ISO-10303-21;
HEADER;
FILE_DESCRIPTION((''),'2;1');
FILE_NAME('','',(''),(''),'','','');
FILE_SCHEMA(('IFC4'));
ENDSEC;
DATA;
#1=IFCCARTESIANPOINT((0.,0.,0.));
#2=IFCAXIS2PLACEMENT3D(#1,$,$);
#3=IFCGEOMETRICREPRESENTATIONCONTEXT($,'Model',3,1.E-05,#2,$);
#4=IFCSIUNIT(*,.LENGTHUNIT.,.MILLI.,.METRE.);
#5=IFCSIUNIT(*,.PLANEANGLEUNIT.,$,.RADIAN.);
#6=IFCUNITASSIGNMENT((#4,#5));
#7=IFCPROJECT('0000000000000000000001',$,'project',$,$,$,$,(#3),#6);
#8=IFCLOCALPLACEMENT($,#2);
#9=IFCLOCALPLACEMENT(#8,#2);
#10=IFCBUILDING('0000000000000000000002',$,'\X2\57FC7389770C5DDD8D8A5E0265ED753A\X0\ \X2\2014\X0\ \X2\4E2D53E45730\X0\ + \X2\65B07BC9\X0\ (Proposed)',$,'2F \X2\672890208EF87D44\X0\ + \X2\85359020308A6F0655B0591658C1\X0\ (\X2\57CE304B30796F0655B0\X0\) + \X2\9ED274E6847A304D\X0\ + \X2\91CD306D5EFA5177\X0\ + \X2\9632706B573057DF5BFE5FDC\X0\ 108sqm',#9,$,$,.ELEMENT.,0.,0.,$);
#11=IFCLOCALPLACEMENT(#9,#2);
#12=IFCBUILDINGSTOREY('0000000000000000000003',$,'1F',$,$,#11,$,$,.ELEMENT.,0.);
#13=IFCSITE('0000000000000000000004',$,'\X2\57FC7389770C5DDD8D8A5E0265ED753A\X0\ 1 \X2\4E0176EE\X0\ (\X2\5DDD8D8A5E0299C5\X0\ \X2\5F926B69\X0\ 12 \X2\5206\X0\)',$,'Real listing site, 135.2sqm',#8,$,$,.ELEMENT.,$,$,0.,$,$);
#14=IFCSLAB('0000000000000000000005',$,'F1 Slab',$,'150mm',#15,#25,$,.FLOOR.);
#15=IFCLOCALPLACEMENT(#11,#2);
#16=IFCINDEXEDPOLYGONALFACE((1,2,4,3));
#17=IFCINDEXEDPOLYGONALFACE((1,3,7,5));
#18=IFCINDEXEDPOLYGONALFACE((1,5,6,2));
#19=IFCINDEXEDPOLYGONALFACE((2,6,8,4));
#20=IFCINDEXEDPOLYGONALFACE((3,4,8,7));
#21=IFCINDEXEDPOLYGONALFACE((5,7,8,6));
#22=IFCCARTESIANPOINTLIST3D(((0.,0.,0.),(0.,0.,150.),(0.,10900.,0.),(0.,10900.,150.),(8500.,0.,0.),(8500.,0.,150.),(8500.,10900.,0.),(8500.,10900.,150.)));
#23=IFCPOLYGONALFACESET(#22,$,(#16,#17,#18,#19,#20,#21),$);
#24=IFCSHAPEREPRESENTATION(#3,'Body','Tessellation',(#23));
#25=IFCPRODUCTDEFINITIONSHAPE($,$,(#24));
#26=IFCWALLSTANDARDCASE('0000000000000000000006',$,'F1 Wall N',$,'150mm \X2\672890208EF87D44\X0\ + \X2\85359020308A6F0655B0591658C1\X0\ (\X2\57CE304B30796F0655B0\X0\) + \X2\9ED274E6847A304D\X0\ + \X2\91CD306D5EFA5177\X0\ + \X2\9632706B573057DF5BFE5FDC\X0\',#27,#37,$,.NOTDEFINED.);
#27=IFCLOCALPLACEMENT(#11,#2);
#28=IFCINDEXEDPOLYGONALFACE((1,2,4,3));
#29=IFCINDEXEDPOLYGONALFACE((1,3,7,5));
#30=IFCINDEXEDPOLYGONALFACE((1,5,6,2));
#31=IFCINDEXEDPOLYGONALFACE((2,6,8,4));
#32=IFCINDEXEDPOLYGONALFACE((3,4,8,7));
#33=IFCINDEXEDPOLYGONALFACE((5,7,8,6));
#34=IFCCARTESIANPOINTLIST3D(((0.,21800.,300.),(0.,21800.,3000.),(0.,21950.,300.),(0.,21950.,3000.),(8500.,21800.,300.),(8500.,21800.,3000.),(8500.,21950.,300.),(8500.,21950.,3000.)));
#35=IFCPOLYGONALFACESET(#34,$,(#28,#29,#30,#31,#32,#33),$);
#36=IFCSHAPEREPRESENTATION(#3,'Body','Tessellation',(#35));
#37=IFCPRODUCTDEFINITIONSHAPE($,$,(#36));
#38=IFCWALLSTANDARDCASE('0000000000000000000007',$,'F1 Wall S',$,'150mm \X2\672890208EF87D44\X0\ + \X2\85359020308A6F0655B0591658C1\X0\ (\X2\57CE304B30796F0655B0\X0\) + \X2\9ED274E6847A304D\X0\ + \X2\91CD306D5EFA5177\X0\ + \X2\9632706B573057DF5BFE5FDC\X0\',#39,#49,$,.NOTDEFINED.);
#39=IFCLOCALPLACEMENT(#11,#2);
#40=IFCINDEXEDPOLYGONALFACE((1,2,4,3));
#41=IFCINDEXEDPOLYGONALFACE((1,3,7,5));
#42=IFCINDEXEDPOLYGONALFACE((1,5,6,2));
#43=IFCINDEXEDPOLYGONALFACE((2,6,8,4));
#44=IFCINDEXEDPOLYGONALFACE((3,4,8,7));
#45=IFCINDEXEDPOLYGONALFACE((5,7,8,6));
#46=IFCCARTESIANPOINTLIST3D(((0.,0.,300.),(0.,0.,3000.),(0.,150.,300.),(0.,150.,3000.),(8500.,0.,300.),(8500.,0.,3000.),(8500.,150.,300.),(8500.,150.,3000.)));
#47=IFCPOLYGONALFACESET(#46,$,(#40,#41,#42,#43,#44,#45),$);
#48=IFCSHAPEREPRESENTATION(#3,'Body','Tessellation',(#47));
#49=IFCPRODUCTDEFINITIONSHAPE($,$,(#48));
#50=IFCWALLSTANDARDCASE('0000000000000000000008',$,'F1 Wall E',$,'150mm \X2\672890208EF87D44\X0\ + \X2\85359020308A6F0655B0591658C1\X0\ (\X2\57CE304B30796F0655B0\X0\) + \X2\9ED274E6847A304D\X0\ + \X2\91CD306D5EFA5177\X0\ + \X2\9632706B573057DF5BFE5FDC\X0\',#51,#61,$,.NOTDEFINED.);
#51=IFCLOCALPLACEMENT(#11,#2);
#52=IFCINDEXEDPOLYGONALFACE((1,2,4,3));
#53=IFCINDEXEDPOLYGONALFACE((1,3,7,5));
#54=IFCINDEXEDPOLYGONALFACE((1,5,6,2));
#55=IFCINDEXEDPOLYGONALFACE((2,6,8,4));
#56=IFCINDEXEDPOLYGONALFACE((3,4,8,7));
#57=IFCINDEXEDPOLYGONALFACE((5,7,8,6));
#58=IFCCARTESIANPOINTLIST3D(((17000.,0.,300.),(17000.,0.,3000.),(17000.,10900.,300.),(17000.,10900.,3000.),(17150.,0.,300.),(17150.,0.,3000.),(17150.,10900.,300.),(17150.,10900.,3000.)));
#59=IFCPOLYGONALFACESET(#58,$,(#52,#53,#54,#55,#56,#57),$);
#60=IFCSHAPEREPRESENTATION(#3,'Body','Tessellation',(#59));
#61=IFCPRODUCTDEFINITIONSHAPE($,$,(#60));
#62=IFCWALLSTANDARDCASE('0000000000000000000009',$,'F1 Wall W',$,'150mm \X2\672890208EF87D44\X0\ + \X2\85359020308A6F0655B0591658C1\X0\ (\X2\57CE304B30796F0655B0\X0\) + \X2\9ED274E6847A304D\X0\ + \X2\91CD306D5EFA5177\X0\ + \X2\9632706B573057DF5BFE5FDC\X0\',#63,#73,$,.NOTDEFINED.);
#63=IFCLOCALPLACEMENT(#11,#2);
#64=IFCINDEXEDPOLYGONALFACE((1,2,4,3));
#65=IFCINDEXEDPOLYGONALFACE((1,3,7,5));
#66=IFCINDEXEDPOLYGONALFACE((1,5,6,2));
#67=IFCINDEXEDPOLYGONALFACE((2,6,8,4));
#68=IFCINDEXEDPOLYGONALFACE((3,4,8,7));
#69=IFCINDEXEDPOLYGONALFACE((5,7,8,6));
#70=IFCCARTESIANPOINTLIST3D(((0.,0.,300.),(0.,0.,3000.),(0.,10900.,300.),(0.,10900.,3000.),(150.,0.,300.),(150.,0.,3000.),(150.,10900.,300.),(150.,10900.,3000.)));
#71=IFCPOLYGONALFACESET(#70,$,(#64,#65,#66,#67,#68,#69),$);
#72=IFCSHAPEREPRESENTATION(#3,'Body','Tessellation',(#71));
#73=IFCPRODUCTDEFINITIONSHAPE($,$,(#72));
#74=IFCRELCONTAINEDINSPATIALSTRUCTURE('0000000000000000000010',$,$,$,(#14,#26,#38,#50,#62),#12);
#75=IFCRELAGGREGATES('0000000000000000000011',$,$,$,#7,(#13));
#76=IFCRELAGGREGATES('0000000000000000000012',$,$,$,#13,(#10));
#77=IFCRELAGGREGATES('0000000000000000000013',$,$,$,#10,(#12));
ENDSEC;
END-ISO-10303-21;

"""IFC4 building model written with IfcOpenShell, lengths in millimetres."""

from ifc_helpers import new_model, si_unit, frame, frame_2d, origin, place, context, project, spatial, rectangle, extrude, element, save


model = new_model("IFC4")

# Units and contexts
model_context = context("Model", 3, precision=1e-05, world=origin())
ifc_project = project(units=[si_unit("LENGTHUNIT", "METRE", prefix="MILLI"), si_unit("PLANEANGLEUNIT", "RADIAN")], contexts=[model_context])

# Site, building, storey
site_placement = place(None, origin())
site = spatial("IfcSite", under=ifc_project, at=site_placement, Name="埼玉県川越市旭町 1 丁目 (川越市駅 徒歩 12 分)", ObjectType="Real listing site, 135.2sqm", CompositionType="ELEMENT", RefElevation=0.0)
building_placement = place(site_placement, origin())
building = spatial("IfcBuilding", under=site, at=building_placement, Name="埼玉県川越市旭町 — 中古地 + 新築 (Proposed)", ObjectType="2F 木造軸組 + 蔵造り漆喰外壁 (城かべ漆喰) + 黒瓦葺き + 重ね建具 + 防火地域対応 108sqm", CompositionType="ELEMENT", ElevationOfRefHeight=0.0, ElevationOfTerrain=0.0)
storey_placement = place(building_placement, origin())
storey = spatial("IfcBuildingStorey", under=building, at=storey_placement, Name="1F", CompositionType="ELEMENT", Elevation=0.0)

# Slab
slab_placement = place(storey_placement, origin())
element("IfcSlab", 1, at=slab_placement, inside=storey, Name="F1 Slab", ObjectType="150mm", PredefinedType="FLOOR", context=model_context, shape_type="SweptSolid", body=[
    extrude(rectangle(XDim=8500.0, YDim=10900.0, at=frame_2d((4250.0, 5450.0))), origin(), (0.0, 0.0, 1.0), 150.0),
])

# Walls
wall_1_placement = place(storey_placement, frame((0.0, 10900.0, 150.0)))
element("IfcWallStandardCase", 2, at=wall_1_placement, inside=storey, Name="F1 Wall N", ObjectType="150mm 木造軸組 + 蔵造り漆喰外壁 (城かべ漆喰) + 黒瓦葺き + 重ね建具 + 防火地域対応", PredefinedType="NOTDEFINED", context=model_context, shape_type="SweptSolid", body=[
    extrude(rectangle(XDim=8500.0, YDim=150.0, at=frame_2d((4250.0, 75.0))), frame((0.0, 10900.0, 150.0)), (0.0, 0.0, 1.0), 2700.0),
])
wall_2_placement = place(storey_placement, frame((0.0, 0.0, 150.0)))
element("IfcWallStandardCase", 3, at=wall_2_placement, inside=storey, Name="F1 Wall S", ObjectType="150mm 木造軸組 + 蔵造り漆喰外壁 (城かべ漆喰) + 黒瓦葺き + 重ね建具 + 防火地域対応", PredefinedType="NOTDEFINED", context=model_context, shape_type="SweptSolid", body=[
    extrude(rectangle(XDim=8500.0, YDim=150.0, at=frame_2d((4250.0, 75.0))), frame((0.0, 0.0, 150.0)), (0.0, 0.0, 1.0), 2700.0),
])
wall_3_placement = place(storey_placement, frame((8500.0, 0.0, 150.0)))
element("IfcWallStandardCase", 4, at=wall_3_placement, inside=storey, Name="F1 Wall E", ObjectType="150mm 木造軸組 + 蔵造り漆喰外壁 (城かべ漆喰) + 黒瓦葺き + 重ね建具 + 防火地域対応", PredefinedType="NOTDEFINED", context=model_context, shape_type="SweptSolid", body=[
    extrude(rectangle(XDim=150.0, YDim=10900.0, at=frame_2d((75.0, 5450.0))), frame((8500.0, 0.0, 150.0)), (0.0, 0.0, 1.0), 2700.0),
])
wall_4_placement = place(storey_placement, frame((0.0, 0.0, 150.0)))
element("IfcWallStandardCase", 5, at=wall_4_placement, inside=storey, Name="F1 Wall W", ObjectType="150mm 木造軸組 + 蔵造り漆喰外壁 (城かべ漆喰) + 黒瓦葺き + 重ね建具 + 防火地域対応", PredefinedType="NOTDEFINED", context=model_context, shape_type="SweptSolid", body=[
    extrude(rectangle(XDim=150.0, YDim=10900.0, at=frame_2d((75.0, 5450.0))), frame((0.0, 0.0, 150.0)), (0.0, 0.0, 1.0), 2700.0),
])

save(model, "model.ifc")
